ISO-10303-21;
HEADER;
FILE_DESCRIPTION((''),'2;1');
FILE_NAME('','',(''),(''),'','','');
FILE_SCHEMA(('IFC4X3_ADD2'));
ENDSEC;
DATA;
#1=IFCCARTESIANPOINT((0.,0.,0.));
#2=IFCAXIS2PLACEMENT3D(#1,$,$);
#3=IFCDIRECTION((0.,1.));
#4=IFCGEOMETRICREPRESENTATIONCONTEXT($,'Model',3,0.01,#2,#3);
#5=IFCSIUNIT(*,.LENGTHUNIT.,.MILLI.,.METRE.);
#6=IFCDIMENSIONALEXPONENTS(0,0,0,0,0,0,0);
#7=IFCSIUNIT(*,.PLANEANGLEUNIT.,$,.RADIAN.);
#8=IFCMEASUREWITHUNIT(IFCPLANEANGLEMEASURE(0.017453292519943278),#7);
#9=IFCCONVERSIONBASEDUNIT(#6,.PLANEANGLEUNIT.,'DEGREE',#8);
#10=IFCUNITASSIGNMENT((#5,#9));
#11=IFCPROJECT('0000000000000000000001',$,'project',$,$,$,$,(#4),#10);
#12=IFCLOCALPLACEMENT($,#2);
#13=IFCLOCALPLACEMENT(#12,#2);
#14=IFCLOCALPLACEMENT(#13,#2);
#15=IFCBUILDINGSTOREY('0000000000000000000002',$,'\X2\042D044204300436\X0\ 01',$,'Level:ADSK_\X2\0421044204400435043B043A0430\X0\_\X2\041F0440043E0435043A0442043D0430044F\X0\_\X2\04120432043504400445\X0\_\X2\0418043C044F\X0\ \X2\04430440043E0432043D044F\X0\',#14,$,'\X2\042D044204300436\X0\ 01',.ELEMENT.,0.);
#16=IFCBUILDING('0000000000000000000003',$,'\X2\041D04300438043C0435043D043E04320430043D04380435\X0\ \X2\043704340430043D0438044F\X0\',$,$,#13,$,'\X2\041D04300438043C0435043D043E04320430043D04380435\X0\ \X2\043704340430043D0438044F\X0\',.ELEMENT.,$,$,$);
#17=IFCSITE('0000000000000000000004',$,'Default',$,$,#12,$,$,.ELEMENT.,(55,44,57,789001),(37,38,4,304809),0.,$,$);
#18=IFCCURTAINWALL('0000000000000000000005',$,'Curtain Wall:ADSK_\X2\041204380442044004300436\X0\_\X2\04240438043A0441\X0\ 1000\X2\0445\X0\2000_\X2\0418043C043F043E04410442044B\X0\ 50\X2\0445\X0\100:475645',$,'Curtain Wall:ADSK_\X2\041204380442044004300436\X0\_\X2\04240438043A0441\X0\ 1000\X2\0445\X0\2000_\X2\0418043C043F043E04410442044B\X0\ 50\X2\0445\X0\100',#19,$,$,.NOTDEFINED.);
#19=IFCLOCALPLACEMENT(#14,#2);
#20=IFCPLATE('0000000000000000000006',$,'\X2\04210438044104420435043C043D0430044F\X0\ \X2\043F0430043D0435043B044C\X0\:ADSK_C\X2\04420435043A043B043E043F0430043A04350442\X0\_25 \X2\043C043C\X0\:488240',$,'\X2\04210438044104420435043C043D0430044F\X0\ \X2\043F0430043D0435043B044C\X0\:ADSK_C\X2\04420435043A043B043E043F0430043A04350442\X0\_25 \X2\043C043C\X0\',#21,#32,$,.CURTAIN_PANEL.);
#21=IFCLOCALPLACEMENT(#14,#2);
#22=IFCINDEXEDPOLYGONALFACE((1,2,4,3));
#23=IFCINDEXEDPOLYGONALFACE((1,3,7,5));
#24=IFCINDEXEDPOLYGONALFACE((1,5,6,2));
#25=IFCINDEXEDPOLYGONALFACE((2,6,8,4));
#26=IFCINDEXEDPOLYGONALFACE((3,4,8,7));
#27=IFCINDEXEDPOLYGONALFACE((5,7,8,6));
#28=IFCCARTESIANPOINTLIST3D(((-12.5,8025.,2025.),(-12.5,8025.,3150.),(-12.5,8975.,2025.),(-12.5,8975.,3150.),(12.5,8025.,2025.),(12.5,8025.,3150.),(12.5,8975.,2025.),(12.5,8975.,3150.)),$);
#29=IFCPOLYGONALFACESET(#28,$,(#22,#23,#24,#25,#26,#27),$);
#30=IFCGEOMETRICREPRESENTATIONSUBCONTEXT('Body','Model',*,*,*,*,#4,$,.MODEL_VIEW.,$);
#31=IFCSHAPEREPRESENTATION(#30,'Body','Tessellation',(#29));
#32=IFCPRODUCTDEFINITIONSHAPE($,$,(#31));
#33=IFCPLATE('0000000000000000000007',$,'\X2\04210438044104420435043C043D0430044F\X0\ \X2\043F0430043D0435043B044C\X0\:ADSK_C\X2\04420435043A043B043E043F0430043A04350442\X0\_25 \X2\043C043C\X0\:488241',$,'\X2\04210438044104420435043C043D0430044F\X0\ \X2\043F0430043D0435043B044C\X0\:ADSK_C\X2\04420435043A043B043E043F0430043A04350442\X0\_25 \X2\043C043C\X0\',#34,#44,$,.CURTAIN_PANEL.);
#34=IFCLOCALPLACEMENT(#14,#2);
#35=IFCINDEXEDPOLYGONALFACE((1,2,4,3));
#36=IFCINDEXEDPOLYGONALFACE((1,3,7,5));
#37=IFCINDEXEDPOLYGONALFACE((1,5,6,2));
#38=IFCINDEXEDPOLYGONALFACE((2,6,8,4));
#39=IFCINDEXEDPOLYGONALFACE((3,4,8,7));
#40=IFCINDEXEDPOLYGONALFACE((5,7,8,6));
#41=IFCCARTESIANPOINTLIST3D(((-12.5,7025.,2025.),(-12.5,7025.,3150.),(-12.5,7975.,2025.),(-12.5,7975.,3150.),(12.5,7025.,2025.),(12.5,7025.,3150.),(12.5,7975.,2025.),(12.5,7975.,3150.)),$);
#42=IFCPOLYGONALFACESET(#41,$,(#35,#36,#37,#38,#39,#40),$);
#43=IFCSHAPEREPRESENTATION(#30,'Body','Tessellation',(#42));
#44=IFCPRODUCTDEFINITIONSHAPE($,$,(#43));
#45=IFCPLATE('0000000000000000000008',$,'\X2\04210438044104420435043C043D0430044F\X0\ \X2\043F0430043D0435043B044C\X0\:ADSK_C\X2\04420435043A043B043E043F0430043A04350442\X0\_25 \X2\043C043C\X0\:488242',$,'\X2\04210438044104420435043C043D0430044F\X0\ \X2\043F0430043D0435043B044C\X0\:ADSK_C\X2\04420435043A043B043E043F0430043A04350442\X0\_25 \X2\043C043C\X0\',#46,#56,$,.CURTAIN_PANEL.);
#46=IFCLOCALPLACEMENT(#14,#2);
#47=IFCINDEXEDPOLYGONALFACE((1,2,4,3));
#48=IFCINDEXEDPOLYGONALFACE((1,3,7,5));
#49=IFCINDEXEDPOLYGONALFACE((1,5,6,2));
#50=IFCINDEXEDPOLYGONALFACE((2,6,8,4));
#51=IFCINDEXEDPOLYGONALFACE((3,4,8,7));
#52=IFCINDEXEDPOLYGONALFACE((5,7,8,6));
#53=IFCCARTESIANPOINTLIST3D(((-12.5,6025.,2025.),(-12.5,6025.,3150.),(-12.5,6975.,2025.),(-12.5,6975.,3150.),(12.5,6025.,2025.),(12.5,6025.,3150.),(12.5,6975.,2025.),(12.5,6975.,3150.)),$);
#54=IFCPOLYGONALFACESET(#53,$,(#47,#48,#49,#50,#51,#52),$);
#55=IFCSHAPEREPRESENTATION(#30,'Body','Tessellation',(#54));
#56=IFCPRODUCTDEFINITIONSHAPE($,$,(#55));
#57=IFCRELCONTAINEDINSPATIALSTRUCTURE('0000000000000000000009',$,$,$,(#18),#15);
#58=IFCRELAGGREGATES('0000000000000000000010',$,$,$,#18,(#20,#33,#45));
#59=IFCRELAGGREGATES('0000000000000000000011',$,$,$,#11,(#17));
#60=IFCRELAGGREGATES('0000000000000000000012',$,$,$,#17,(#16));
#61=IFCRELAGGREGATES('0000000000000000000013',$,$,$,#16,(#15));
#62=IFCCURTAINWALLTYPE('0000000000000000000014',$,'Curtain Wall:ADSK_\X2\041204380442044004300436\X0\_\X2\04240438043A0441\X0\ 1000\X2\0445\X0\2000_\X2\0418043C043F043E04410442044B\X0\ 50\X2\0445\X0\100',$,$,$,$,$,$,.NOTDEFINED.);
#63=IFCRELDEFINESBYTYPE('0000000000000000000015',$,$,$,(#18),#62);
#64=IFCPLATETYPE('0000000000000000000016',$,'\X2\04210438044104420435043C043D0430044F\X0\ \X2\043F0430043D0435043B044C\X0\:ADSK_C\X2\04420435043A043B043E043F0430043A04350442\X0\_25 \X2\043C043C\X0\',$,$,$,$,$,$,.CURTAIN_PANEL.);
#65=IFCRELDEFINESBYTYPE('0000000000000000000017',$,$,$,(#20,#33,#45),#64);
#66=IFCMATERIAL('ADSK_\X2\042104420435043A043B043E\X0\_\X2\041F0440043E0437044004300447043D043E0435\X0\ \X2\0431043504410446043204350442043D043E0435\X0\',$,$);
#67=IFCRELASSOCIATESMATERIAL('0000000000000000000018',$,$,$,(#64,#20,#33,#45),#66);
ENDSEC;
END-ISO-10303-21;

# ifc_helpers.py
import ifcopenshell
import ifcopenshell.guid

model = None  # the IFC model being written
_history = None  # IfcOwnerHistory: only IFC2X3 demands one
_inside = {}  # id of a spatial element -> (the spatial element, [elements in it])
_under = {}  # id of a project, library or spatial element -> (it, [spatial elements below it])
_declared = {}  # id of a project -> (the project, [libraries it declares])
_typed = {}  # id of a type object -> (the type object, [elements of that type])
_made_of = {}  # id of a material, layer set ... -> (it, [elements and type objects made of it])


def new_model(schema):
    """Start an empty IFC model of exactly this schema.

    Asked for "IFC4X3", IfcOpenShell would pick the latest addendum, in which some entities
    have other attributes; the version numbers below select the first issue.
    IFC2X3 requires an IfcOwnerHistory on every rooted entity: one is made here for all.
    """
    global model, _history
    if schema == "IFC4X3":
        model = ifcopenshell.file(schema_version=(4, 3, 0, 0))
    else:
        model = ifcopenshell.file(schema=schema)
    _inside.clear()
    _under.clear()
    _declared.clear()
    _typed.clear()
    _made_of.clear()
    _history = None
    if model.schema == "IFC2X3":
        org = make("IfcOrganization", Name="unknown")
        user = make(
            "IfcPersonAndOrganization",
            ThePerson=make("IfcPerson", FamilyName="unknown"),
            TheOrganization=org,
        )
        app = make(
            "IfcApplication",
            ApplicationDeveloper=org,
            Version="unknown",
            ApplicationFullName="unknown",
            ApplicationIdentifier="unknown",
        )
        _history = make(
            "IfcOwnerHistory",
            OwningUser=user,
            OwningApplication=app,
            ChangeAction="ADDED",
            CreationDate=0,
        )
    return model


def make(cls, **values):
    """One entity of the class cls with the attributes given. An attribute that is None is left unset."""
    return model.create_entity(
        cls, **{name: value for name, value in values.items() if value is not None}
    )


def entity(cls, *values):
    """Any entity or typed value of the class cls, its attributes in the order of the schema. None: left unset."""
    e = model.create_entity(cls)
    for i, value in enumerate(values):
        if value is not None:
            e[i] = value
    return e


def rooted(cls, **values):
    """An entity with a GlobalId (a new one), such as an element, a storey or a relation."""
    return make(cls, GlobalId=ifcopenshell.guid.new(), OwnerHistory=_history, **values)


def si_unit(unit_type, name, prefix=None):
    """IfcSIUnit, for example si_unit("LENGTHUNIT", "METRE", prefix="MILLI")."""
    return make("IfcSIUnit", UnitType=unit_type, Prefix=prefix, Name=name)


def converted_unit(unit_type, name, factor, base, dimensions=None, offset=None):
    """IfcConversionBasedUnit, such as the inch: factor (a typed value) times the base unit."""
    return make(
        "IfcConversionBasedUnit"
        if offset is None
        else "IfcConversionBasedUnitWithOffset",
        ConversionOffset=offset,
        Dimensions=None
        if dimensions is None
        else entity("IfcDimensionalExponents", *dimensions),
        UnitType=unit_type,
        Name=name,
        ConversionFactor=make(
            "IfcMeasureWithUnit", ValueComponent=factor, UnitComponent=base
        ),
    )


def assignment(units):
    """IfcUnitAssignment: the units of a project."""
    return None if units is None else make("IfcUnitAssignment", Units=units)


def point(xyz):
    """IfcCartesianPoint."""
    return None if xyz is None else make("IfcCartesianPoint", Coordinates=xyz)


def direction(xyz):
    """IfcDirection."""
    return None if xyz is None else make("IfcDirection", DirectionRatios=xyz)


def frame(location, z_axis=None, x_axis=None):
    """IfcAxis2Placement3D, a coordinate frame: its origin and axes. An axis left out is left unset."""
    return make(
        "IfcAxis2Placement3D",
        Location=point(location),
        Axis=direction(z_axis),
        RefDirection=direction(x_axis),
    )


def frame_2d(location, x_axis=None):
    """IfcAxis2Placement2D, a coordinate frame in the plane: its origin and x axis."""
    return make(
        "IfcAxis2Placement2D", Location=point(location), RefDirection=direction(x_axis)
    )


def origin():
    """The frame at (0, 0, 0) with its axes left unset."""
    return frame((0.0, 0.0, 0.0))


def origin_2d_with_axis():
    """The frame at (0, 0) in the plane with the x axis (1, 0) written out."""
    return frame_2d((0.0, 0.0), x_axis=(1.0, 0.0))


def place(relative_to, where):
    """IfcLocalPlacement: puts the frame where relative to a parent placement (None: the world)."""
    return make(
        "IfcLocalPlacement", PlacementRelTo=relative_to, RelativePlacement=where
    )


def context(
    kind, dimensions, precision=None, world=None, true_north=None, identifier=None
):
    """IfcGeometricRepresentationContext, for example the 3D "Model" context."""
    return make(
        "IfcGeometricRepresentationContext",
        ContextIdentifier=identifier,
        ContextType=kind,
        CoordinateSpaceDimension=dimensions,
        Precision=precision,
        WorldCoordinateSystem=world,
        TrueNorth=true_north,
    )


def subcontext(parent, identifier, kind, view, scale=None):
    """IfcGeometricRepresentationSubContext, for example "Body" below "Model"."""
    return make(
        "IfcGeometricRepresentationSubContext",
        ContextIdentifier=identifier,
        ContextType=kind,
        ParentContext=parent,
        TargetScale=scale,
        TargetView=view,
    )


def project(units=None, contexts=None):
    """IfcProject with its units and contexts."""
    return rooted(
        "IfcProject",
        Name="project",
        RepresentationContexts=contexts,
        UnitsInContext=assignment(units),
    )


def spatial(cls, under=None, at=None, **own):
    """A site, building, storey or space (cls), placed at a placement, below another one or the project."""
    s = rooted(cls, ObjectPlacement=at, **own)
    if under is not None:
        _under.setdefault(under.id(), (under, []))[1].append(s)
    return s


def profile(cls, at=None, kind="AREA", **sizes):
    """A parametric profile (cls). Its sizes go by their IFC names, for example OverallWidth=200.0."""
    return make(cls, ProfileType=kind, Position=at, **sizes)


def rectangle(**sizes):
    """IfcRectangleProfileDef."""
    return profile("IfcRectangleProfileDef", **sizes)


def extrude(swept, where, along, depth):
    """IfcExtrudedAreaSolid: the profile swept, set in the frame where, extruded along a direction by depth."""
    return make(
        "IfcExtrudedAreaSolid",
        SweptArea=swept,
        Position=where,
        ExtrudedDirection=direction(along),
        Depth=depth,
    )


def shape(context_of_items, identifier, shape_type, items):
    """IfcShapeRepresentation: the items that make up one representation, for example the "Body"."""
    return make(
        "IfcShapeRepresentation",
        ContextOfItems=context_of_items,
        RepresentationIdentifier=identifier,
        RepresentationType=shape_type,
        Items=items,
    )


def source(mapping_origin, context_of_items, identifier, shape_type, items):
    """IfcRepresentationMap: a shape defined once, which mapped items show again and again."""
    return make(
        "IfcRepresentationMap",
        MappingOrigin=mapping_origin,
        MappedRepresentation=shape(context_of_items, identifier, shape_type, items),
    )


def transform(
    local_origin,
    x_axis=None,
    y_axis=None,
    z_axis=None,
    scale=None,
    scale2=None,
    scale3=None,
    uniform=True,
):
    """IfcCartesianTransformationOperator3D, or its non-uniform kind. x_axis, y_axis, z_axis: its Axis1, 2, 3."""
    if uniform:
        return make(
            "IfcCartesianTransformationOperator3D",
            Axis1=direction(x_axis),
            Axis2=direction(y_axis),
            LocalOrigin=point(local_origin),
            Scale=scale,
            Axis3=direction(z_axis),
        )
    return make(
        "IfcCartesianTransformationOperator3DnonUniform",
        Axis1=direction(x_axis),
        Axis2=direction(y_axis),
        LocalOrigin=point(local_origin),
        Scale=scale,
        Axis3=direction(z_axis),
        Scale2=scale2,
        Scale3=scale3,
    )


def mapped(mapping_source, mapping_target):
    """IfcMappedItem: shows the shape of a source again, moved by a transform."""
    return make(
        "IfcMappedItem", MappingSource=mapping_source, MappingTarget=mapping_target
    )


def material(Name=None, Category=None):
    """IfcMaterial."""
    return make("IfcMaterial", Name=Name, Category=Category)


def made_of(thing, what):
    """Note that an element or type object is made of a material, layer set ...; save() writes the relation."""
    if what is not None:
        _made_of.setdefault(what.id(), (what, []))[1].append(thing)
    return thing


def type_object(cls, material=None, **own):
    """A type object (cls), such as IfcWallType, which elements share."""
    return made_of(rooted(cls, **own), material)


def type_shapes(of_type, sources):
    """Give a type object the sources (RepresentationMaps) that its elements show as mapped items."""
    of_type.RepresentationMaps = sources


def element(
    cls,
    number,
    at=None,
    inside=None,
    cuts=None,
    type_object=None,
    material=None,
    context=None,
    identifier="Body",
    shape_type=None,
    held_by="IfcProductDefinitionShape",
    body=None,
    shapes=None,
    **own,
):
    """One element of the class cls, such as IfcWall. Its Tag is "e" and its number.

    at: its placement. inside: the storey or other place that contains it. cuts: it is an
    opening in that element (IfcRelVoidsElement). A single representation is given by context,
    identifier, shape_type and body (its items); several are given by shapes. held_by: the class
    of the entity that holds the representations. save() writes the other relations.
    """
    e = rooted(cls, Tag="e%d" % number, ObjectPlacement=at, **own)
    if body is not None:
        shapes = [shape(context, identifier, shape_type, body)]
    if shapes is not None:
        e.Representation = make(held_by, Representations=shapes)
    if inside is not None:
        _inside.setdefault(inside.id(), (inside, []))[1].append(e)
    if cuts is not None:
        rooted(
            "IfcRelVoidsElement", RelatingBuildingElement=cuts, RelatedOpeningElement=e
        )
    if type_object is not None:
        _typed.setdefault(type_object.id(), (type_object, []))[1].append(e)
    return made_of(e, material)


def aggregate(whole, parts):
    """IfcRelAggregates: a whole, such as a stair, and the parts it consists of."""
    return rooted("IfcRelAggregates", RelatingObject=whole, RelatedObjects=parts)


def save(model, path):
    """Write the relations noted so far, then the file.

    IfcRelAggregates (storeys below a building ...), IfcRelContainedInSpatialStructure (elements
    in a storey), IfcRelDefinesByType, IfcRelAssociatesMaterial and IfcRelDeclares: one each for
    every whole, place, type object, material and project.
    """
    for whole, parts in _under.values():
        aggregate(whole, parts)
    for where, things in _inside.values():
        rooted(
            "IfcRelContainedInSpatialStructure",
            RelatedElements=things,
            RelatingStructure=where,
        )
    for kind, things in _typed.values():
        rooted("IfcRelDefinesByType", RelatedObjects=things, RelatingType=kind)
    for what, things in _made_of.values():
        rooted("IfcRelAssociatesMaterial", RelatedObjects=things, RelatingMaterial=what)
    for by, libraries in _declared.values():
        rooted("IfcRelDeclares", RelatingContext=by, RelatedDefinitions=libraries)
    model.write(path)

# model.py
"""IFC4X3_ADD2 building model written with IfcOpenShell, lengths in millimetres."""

from ifc_helpers import new_model, entity, si_unit, converted_unit, direction, frame, origin, origin_2d_with_axis, place, context, subcontext, project, spatial, rectangle, extrude, source, transform, mapped, material, type_object, type_shapes, element, aggregate, save


model = new_model("IFC4X3_ADD2")

# Units and contexts
model_context = context("Model", 3, precision=0.01, world=origin(), true_north=direction((0.0, 1.0)))
body_context = subcontext(model_context, "Body", "Model", "MODEL_VIEW")
ifc_project = project(units=[si_unit("LENGTHUNIT", "METRE", prefix="MILLI"), converted_unit("PLANEANGLEUNIT", "DEGREE", entity("IfcPlaneAngleMeasure", 0.017453292519943278), si_unit("PLANEANGLEUNIT", "RADIAN"), dimensions=[0, 0, 0, 0, 0, 0, 0])], contexts=[model_context])

# Site, building, storey
site_placement = place(None, origin())
site = spatial("IfcSite", under=ifc_project, at=site_placement, Name="Default", CompositionType="ELEMENT", RefLatitude=(55, 44, 57, 789001), RefLongitude=(37, 38, 4, 304809), RefElevation=0.0)
building_placement = place(site_placement, origin())
building = spatial("IfcBuilding", under=site, at=building_placement, Name="Наименование здания", LongName="Наименование здания", CompositionType="ELEMENT")
storey_placement = place(building_placement, origin())
storey = spatial("IfcBuildingStorey", under=building, at=storey_placement, Name="Этаж 01", ObjectType="Level:ADSK_Стрелка_Проектная_Вверх_Имя уровня", LongName="Этаж 01", CompositionType="ELEMENT", Elevation=0.0)

# Curtain wall, plates
curtain_wall_type = type_object("IfcCurtainWallType", Name="Curtain Wall:ADSK_Витраж_Фикс 1000х2000_Импосты 50х100", PredefinedType="NOTDEFINED")
curtain_wall_placement = place(storey_placement, origin())
curtain_wall = element("IfcCurtainWall", 1, at=curtain_wall_placement, inside=storey, type_object=curtain_wall_type, Name="Curtain Wall:ADSK_Витраж_Фикс 1000х2000_Импосты 50х100:475645", ObjectType="Curtain Wall:ADSK_Витраж_Фикс 1000х2000_Импосты 50х100", PredefinedType="NOTDEFINED")
ifc_material = material(Name="ADSK_Стекло_Прозрачное бесцветное")
plate_type_1 = type_object("IfcPlateType", Name="Системная панель:ADSK_Cтеклопакет_25 мм", PredefinedType="CURTAIN_PANEL", material=ifc_material)
shared_shape_1 = source(origin(), body_context, "Body", "SweptSolid", [
    extrude(rectangle(XDim=25.0, YDim=950.0, at=origin_2d_with_axis()), frame((0.0, 0.0, 0.0), z_axis=(0.0, 0.0, 1.0), x_axis=(0.0, 1.0, 0.0)), (0.0, 0.0, 1.0), 1125.0),
])
type_shapes(plate_type_1, [shared_shape_1])
plate_1_placement = place(curtain_wall_placement, frame((0.0, 8500.0, 2025.0), z_axis=(0.0, 0.0, 1.0), x_axis=(0.0, -1.0, 0.0)))
plate_1 = element("IfcPlate", 2, at=plate_1_placement, type_object=plate_type_1, material=ifc_material, Name="Системная панель:ADSK_Cтеклопакет_25 мм:488240", ObjectType="Системная панель:ADSK_Cтеклопакет_25 мм", PredefinedType="CURTAIN_PANEL", context=body_context, shape_type="MappedRepresentation", body=[
    mapped(shared_shape_1, transform((0.0, 0.0, 0.0), scale=1.0)),
])
plate_2_placement = place(curtain_wall_placement, frame((0.0, 7500.0, 2025.0), z_axis=(0.0, 0.0, 1.0), x_axis=(0.0, -1.0, 0.0)))
plate_2 = element("IfcPlate", 3, at=plate_2_placement, type_object=plate_type_1, material=ifc_material, Name="Системная панель:ADSK_Cтеклопакет_25 мм:488241", ObjectType="Системная панель:ADSK_Cтеклопакет_25 мм", PredefinedType="CURTAIN_PANEL", context=body_context, shape_type="MappedRepresentation", body=[
    mapped(shared_shape_1, transform((0.0, 0.0, 0.0), scale=1.0)),
])
plate_3_placement = place(curtain_wall_placement, frame((0.0, 6500.0, 2025.0), z_axis=(0.0, 0.0, 1.0), x_axis=(0.0, -1.0, 0.0)))
plate_3 = element("IfcPlate", 4, at=plate_3_placement, type_object=plate_type_1, material=ifc_material, Name="Системная панель:ADSK_Cтеклопакет_25 мм:488242", ObjectType="Системная панель:ADSK_Cтеклопакет_25 мм", PredefinedType="CURTAIN_PANEL", context=body_context, shape_type="MappedRepresentation", body=[
    mapped(shared_shape_1, transform((0.0, 0.0, 0.0), scale=1.0)),
])
aggregate(curtain_wall, [plate_1, plate_2, plate_3])

save(model, "model.ifc")
